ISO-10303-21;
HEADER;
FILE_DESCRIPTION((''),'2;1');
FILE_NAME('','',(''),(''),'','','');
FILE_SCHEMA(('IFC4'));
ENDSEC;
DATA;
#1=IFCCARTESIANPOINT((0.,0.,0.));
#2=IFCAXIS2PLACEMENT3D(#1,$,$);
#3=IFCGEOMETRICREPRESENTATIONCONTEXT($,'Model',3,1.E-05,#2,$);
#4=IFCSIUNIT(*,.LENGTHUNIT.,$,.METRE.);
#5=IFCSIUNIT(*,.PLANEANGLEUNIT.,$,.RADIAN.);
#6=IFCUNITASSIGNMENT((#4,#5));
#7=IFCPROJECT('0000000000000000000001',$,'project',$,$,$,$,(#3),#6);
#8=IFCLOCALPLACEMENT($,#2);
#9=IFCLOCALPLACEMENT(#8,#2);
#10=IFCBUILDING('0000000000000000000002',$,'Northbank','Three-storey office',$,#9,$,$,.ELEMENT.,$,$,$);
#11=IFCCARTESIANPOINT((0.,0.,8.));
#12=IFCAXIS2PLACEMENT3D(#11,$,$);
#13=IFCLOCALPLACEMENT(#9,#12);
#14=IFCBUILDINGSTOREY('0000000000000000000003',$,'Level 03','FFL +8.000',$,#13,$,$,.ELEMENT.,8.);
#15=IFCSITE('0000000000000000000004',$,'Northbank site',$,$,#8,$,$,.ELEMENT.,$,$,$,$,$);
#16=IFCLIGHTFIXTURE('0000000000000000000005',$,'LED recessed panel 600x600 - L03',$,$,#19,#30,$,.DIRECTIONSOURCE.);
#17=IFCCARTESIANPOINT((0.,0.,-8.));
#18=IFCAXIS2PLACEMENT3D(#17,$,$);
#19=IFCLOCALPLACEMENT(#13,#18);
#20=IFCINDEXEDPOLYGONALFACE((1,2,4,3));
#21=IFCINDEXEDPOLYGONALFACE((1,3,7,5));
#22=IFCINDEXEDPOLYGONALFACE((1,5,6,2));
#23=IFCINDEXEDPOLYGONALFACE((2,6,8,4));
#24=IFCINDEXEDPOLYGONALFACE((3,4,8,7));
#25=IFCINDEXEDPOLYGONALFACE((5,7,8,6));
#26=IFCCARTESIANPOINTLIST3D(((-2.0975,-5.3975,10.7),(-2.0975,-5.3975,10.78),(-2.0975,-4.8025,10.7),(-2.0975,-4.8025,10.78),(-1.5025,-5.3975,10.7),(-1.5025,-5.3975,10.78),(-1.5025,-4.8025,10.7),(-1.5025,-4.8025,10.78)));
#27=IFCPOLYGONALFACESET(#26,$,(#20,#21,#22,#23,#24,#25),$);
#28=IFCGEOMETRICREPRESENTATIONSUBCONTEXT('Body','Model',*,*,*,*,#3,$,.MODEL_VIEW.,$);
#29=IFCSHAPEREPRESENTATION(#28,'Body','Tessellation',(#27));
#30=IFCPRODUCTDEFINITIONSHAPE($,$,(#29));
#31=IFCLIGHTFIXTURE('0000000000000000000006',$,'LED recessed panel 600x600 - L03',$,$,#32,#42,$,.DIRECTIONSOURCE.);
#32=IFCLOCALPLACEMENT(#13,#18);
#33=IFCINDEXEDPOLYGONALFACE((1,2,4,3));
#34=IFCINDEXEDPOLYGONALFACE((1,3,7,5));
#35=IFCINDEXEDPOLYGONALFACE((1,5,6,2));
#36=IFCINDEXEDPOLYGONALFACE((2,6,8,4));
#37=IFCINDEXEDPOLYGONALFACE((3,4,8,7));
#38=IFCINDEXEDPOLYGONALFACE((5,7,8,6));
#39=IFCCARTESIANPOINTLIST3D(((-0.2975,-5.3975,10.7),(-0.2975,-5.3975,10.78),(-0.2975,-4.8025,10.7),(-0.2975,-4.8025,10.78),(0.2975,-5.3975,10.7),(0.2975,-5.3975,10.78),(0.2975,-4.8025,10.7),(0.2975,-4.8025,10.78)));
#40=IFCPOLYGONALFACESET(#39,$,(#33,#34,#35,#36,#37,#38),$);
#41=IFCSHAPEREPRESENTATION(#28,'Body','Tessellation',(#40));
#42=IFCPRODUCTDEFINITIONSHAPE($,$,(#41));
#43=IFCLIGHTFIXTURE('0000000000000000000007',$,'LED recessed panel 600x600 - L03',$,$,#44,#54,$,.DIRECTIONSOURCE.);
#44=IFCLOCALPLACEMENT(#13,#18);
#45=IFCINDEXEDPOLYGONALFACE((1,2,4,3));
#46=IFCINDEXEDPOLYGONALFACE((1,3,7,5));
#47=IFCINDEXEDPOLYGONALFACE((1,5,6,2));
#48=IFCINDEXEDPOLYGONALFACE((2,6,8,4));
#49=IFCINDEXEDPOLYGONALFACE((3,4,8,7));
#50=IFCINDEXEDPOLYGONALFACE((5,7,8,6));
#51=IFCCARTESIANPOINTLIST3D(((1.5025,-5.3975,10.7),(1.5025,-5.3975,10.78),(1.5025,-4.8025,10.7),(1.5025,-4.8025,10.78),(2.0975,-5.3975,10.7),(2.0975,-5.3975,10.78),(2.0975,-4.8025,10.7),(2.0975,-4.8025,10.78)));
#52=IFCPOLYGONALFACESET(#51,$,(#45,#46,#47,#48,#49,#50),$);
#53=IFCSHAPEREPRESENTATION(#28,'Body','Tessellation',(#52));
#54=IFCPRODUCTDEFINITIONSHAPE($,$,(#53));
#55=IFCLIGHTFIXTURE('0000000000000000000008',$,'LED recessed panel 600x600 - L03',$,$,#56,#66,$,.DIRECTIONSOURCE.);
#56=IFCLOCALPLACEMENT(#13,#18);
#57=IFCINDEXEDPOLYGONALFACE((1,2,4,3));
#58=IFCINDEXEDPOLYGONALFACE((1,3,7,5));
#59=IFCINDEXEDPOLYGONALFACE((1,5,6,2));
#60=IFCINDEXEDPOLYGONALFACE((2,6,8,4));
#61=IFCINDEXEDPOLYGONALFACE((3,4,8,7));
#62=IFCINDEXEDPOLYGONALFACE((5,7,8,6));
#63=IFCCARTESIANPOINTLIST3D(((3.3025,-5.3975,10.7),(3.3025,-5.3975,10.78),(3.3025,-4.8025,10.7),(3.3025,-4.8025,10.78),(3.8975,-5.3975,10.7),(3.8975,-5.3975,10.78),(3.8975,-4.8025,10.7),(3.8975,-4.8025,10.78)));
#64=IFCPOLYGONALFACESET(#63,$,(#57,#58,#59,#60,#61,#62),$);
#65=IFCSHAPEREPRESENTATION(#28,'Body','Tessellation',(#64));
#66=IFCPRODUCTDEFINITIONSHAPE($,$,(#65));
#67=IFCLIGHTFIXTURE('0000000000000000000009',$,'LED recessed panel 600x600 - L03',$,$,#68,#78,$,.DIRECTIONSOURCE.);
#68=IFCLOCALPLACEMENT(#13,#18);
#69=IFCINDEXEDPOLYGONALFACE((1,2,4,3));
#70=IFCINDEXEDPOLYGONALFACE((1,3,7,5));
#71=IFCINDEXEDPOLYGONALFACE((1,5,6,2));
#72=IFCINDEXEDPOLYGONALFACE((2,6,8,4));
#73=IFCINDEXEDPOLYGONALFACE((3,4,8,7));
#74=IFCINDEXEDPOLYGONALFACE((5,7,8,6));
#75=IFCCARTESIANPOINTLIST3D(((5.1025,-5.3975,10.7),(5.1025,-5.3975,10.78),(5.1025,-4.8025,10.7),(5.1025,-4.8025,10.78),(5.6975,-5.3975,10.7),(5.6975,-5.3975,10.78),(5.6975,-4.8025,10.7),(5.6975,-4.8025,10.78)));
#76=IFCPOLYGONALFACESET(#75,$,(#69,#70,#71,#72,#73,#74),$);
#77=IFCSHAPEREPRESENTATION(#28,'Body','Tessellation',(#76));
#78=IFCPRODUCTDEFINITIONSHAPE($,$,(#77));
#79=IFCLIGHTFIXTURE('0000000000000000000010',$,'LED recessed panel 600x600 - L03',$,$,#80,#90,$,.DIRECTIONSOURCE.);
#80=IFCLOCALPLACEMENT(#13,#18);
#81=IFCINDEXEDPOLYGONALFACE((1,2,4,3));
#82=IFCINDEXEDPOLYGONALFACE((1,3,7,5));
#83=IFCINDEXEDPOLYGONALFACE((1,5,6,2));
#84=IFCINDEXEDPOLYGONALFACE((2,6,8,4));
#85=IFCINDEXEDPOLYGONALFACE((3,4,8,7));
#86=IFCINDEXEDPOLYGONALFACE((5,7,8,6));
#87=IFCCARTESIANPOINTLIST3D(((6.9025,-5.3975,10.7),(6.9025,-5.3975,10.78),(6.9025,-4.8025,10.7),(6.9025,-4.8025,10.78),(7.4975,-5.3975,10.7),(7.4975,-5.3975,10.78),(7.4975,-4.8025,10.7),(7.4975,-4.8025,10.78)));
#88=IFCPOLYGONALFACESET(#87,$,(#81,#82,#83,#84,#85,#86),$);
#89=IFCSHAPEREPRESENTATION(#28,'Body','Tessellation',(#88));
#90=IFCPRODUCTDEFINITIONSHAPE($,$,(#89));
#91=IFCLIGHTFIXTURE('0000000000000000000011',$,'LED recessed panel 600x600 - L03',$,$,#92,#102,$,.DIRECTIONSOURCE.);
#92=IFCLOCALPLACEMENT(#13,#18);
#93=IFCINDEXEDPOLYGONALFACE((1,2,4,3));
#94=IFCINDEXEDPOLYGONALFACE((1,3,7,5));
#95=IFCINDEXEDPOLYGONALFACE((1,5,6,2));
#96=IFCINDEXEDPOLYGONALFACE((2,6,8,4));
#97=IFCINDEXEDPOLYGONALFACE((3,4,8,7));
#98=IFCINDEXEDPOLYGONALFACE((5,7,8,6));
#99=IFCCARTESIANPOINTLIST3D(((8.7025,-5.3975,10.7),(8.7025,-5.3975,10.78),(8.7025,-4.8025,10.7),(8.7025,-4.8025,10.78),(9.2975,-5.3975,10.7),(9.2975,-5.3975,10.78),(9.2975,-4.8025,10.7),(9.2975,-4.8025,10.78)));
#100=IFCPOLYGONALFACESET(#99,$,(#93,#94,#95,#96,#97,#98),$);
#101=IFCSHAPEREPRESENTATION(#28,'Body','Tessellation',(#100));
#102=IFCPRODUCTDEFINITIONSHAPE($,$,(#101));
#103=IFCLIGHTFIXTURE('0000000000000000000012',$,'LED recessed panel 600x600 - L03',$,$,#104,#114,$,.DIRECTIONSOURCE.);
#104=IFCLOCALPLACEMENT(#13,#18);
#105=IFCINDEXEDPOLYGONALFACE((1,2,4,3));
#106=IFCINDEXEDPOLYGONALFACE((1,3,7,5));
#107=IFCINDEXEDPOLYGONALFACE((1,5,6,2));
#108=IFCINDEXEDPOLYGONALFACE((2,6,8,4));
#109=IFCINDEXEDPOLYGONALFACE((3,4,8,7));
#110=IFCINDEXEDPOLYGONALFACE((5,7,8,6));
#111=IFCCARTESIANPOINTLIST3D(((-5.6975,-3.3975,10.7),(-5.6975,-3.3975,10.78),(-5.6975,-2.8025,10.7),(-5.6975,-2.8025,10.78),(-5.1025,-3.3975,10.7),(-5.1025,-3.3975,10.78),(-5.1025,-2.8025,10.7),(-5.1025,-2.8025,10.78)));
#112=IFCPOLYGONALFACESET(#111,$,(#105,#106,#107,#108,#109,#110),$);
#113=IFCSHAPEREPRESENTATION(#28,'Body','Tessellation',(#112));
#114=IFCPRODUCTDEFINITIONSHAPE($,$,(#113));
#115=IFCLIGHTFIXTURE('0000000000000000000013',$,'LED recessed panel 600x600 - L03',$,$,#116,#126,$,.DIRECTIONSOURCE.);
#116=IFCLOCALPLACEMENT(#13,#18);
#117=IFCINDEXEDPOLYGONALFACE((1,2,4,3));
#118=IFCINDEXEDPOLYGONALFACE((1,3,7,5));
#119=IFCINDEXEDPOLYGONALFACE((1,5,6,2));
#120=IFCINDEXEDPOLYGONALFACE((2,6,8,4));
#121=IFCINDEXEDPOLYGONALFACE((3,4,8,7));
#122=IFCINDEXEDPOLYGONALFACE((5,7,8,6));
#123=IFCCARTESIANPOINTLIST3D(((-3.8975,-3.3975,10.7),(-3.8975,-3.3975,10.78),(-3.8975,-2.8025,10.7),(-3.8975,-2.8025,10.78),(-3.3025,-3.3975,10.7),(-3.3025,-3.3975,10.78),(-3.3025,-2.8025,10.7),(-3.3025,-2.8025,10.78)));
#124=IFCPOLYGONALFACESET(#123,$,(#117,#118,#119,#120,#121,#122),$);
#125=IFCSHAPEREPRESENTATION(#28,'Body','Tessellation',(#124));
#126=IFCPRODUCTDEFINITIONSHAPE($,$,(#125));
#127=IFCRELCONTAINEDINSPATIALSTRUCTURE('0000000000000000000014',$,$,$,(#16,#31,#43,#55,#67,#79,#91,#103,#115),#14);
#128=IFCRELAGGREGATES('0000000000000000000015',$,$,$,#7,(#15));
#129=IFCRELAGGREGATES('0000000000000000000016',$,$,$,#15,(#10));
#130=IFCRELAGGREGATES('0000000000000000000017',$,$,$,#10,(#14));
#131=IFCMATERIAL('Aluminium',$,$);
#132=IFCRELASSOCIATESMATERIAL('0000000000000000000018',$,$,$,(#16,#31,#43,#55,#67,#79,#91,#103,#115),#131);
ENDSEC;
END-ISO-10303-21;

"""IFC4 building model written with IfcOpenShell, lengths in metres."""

from ifc_helpers import new_model, si_unit, frame, origin, place, context, subcontext, project, spatial, rectangle, extrude, material, element, save


model = new_model("IFC4")

# Units and contexts
model_context = context("Model", 3, precision=1e-05, world=origin())
body_context = subcontext(model_context, "Body", "Model", "MODEL_VIEW")
ifc_project = project(units=[si_unit("LENGTHUNIT", "METRE"), si_unit("PLANEANGLEUNIT", "RADIAN")], contexts=[model_context])

# Site, building, storey
site_placement = place(None, origin())
site = spatial("IfcSite", under=ifc_project, at=site_placement, Name="Northbank site", CompositionType="ELEMENT")
building_placement = place(site_placement, origin())
building = spatial("IfcBuilding", under=site, at=building_placement, Name="Northbank", Description="Three-storey office", CompositionType="ELEMENT")
storey_placement = place(building_placement, frame((0.0, 0.0, 8.0)))
storey = spatial("IfcBuildingStorey", under=building, at=storey_placement, Name="Level 03", Description="FFL +8.000", CompositionType="ELEMENT", Elevation=8.0)

# Light fixtures
ifc_material_1 = material(Name="Aluminium")
light_fixture_1_placement = place(storey_placement, frame((0.0, 0.0, -8.0)))
element("IfcLightFixture", 1, at=light_fixture_1_placement, inside=storey, material=ifc_material_1, Name="LED recessed panel 600x600 - L03", PredefinedType="DIRECTIONSOURCE", context=body_context, shape_type="SweptSolid", body=[
    extrude(rectangle(XDim=0.595, YDim=0.595), frame((-1.8, -5.1, 10.7)), (0.0, 0.0, 1.0), 0.08),
])
light_fixture_2_placement = place(storey_placement, frame((0.0, 0.0, -8.0)))
element("IfcLightFixture", 2, at=light_fixture_2_placement, inside=storey, material=ifc_material_1, Name="LED recessed panel 600x600 - L03", PredefinedType="DIRECTIONSOURCE", context=body_context, shape_type="SweptSolid", body=[
    extrude(rectangle(XDim=0.595, YDim=0.595), frame((0.0, -5.1, 10.7)), (0.0, 0.0, 1.0), 0.08),
])
light_fixture_3_placement = place(storey_placement, frame((0.0, 0.0, -8.0)))
element("IfcLightFixture", 3, at=light_fixture_3_placement, inside=storey, material=ifc_material_1, Name="LED recessed panel 600x600 - L03", PredefinedType="DIRECTIONSOURCE", context=body_context, shape_type="SweptSolid", body=[
    extrude(rectangle(XDim=0.595, YDim=0.595), frame((1.8, -5.1, 10.7)), (0.0, 0.0, 1.0), 0.08),
])
light_fixture_4_placement = place(storey_placement, frame((0.0, 0.0, -8.0)))
element("IfcLightFixture", 4, at=light_fixture_4_placement, inside=storey, material=ifc_material_1, Name="LED recessed panel 600x600 - L03", PredefinedType="DIRECTIONSOURCE", context=body_context, shape_type="SweptSolid", body=[
    extrude(rectangle(XDim=0.595, YDim=0.595), frame((3.6, -5.1, 10.7)), (0.0, 0.0, 1.0), 0.08),
])
light_fixture_5_placement = place(storey_placement, frame((0.0, 0.0, -8.0)))
element("IfcLightFixture", 5, at=light_fixture_5_placement, inside=storey, material=ifc_material_1, Name="LED recessed panel 600x600 - L03", PredefinedType="DIRECTIONSOURCE", context=body_context, shape_type="SweptSolid", body=[
    extrude(rectangle(XDim=0.595, YDim=0.595), frame((5.4, -5.1, 10.7)), (0.0, 0.0, 1.0), 0.08),
])
light_fixture_6_placement = place(storey_placement, frame((0.0, 0.0, -8.0)))
element("IfcLightFixture", 6, at=light_fixture_6_placement, inside=storey, material=ifc_material_1, Name="LED recessed panel 600x600 - L03", PredefinedType="DIRECTIONSOURCE", context=body_context, shape_type="SweptSolid", body=[
    extrude(rectangle(XDim=0.595, YDim=0.595), frame((7.2, -5.1, 10.7)), (0.0, 0.0, 1.0), 0.08),
])
light_fixture_7_placement = place(storey_placement, frame((0.0, 0.0, -8.0)))
element("IfcLightFixture", 7, at=light_fixture_7_placement, inside=storey, material=ifc_material_1, Name="LED recessed panel 600x600 - L03", PredefinedType="DIRECTIONSOURCE", context=body_context, shape_type="SweptSolid", body=[
    extrude(rectangle(XDim=0.595, YDim=0.595), frame((9.0, -5.1, 10.7)), (0.0, 0.0, 1.0), 0.08),
])
light_fixture_8_placement = place(storey_placement, frame((0.0, 0.0, -8.0)))
element("IfcLightFixture", 8, at=light_fixture_8_placement, inside=storey, material=ifc_material_1, Name="LED recessed panel 600x600 - L03", PredefinedType="DIRECTIONSOURCE", context=body_context, shape_type="SweptSolid", body=[
    extrude(rectangle(XDim=0.595, YDim=0.595), frame((-5.4, -3.1, 10.7)), (0.0, 0.0, 1.0), 0.08),
])
light_fixture_9_placement = place(storey_placement, frame((0.0, 0.0, -8.0)))
element("IfcLightFixture", 9, at=light_fixture_9_placement, inside=storey, material=ifc_material_1, Name="LED recessed panel 600x600 - L03", PredefinedType="DIRECTIONSOURCE", context=body_context, shape_type="SweptSolid", body=[
    extrude(rectangle(XDim=0.595, YDim=0.595), frame((-3.6, -3.1, 10.7)), (0.0, 0.0, 1.0), 0.08),
])

save(model, "model.ifc")
